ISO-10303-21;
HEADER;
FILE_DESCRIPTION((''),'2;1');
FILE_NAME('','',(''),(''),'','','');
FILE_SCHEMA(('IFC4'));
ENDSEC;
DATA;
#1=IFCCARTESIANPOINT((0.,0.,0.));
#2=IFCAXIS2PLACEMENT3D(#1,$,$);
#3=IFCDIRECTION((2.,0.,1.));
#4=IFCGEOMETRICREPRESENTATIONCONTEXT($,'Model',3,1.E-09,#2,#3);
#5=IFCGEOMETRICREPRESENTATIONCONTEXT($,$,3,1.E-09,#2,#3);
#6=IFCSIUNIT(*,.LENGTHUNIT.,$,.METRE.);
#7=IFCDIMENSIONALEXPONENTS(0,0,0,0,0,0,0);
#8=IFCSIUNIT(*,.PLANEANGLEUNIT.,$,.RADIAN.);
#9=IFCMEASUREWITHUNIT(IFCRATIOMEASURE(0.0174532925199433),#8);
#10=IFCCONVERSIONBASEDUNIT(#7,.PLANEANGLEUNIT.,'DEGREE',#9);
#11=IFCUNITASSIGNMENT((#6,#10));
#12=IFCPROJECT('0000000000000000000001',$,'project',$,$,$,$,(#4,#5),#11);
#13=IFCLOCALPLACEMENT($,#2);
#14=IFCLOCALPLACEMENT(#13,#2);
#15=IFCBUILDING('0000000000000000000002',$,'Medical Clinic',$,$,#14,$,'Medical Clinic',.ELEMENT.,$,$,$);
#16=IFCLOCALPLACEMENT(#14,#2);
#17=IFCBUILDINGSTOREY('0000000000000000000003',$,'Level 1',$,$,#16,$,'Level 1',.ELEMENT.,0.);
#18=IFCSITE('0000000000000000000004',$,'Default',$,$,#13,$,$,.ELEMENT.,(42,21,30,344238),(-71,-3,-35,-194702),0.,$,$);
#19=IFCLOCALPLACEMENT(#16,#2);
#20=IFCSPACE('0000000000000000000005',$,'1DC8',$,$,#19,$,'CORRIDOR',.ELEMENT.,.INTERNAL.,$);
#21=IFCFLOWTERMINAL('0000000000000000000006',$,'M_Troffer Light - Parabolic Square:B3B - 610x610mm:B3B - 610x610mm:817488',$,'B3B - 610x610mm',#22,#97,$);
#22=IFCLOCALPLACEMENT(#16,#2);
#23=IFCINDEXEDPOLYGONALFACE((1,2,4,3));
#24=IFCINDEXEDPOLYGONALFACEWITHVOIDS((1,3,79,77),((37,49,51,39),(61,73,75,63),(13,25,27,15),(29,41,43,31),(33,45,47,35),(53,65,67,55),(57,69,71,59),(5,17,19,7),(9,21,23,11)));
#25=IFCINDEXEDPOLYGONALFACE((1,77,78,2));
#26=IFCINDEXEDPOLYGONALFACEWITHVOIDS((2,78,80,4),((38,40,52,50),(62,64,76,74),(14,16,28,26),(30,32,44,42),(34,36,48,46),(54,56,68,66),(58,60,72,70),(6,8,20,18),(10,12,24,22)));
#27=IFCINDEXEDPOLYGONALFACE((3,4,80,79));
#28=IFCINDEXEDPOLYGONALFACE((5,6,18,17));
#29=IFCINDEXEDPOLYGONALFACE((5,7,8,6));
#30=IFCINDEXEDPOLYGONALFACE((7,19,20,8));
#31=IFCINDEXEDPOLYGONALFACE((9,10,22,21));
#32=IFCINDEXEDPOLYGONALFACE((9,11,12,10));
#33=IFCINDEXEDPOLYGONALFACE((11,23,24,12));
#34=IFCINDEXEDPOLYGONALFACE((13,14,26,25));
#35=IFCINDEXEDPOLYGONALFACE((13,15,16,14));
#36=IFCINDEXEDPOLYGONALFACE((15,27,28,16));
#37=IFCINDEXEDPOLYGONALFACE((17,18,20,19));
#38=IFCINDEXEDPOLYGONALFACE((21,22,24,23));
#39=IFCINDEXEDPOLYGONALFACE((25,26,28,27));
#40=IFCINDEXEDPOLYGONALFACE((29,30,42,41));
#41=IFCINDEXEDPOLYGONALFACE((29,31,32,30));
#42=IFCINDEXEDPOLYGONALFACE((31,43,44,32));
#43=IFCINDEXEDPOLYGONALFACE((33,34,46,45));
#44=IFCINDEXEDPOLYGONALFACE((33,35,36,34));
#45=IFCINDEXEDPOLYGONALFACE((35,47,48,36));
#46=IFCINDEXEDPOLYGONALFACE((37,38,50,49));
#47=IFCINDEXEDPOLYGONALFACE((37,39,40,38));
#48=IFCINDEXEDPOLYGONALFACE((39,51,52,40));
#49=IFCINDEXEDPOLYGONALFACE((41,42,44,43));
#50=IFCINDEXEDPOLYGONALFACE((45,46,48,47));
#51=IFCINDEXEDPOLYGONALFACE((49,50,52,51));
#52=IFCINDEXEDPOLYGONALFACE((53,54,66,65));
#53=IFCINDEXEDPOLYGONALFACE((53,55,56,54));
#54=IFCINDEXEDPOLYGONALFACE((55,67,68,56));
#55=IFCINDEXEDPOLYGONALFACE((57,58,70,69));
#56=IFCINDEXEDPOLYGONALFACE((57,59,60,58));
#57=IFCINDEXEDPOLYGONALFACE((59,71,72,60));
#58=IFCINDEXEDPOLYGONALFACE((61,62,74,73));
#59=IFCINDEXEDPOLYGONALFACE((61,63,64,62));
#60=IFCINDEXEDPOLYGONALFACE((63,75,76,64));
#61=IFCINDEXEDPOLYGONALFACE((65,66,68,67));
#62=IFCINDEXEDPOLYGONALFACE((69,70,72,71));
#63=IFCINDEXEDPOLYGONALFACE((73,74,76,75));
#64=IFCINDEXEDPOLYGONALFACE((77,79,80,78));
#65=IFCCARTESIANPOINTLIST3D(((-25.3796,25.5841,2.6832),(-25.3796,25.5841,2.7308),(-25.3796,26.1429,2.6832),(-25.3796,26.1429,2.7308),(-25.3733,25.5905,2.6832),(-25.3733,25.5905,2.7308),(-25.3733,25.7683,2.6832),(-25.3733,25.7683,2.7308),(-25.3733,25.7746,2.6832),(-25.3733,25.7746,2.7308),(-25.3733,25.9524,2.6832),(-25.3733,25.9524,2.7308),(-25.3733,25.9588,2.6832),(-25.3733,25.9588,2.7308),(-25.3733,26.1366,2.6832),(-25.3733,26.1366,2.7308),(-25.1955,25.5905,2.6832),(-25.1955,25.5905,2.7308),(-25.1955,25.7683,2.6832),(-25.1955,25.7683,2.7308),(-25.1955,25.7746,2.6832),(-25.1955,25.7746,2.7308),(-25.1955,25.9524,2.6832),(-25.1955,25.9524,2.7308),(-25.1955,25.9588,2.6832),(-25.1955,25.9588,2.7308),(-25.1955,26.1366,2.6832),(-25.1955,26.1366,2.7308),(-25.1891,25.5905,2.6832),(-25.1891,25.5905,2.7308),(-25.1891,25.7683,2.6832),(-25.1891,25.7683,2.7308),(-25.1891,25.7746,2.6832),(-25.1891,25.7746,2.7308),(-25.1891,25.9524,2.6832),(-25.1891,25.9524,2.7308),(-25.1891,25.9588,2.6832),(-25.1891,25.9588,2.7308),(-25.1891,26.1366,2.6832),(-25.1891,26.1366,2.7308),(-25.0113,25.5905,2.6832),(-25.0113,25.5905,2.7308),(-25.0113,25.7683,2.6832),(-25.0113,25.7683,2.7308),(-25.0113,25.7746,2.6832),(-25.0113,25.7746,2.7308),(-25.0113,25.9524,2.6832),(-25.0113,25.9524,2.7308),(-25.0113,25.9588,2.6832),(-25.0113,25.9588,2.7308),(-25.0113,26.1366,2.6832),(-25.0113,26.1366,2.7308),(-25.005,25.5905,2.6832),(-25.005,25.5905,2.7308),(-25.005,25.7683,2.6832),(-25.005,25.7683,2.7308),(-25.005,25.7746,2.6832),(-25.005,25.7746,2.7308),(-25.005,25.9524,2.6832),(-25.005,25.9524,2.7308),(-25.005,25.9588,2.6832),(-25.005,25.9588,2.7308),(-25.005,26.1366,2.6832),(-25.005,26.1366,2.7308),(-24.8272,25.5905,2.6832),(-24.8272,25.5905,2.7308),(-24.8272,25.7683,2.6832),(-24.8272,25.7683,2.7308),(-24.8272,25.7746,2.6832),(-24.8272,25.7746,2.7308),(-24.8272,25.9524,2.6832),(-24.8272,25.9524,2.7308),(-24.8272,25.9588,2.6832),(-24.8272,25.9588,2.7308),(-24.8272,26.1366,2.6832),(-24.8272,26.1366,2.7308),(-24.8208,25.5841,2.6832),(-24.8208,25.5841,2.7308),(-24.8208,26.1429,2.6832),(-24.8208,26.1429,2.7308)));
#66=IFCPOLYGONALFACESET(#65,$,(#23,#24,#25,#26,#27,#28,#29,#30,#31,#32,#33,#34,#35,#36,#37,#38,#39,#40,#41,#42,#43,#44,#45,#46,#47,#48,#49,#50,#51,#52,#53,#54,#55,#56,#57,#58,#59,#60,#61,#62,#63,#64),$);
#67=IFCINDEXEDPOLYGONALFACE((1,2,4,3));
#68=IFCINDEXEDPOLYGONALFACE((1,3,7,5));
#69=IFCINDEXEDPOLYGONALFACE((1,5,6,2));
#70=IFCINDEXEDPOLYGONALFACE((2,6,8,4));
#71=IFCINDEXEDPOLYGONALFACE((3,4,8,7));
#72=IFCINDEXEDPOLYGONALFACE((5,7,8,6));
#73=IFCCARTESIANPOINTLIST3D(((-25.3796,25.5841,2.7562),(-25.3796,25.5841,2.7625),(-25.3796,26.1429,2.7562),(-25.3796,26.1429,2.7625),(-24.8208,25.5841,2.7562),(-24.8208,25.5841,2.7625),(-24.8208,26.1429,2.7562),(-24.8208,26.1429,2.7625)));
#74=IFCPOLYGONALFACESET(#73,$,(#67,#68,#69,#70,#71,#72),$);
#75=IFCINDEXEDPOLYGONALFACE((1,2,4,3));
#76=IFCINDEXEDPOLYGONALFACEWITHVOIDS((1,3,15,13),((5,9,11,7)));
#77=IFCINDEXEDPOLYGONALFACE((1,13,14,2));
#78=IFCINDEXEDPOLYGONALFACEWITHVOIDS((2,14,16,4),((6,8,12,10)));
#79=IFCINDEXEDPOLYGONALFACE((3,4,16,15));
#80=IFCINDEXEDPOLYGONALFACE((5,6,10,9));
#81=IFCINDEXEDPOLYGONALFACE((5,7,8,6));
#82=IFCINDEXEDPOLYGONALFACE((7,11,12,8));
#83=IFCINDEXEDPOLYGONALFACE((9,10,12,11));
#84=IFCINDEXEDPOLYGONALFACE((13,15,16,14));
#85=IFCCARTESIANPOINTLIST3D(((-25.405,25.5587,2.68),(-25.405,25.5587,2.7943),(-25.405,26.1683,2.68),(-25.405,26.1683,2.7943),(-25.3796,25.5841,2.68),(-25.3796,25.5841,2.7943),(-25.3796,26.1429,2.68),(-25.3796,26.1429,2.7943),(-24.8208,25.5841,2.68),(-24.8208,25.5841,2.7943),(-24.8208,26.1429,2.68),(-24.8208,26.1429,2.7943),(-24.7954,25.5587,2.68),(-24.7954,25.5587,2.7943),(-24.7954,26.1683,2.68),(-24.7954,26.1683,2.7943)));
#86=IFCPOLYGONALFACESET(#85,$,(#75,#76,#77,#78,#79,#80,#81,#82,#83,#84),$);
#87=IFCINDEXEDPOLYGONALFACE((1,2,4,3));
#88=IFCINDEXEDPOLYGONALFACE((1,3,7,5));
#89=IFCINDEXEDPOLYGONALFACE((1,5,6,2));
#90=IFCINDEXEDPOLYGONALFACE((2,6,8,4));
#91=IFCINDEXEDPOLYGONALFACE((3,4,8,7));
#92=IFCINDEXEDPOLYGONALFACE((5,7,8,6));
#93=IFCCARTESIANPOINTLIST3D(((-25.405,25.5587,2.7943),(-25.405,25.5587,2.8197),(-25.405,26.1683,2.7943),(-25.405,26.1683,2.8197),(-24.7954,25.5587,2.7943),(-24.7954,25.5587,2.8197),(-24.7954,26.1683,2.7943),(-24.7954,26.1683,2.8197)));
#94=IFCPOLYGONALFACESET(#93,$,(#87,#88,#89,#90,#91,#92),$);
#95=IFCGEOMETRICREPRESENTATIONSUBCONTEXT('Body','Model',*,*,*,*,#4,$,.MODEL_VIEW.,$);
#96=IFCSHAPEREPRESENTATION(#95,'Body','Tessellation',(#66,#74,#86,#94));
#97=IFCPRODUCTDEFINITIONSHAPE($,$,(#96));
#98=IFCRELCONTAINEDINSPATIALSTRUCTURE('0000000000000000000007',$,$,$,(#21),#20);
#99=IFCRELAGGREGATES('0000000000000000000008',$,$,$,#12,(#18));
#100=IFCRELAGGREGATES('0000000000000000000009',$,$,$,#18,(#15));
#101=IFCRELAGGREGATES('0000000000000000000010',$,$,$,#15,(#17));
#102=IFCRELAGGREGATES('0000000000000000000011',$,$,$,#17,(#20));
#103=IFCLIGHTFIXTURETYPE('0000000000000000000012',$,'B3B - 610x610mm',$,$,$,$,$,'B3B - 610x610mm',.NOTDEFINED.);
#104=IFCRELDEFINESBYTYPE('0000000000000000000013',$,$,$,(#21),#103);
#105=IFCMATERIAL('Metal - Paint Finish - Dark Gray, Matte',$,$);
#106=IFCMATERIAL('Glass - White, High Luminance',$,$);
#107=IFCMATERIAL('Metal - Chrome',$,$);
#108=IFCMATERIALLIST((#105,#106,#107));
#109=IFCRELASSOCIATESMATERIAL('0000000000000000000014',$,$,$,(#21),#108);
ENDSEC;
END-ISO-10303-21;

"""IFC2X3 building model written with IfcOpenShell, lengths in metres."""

from ifc_helpers import new_model, entity, si_unit, converted_unit, direction, frame, origin, origin_2d_with_axis, place, context, subcontext, project, spatial, polyline, rectangle, outline, extrude, source, transform, mapped, material, material_list, type_object, type_shapes, element, save


model = new_model("IFC2X3")

# Units and contexts
model_context = context("Model", 3, precision=1e-09, world=origin(), true_north=direction((2.0, 0.0, 1.0)))
context_of_model = context(None, 3, precision=1e-09, world=origin(), true_north=direction((2.0, 0.0, 1.0)))
body_context = subcontext(model_context, "Body", "Model", "MODEL_VIEW")
ifc_project = project(units=[si_unit("LENGTHUNIT", "METRE"), converted_unit("PLANEANGLEUNIT", "DEGREE", entity("IfcRatioMeasure", 0.0174532925199433), si_unit("PLANEANGLEUNIT", "RADIAN"), dimensions=[0, 0, 0, 0, 0, 0, 0])], contexts=[model_context, context_of_model])

# Site, building, storey
site_placement = place(None, origin())
site = spatial("IfcSite", under=ifc_project, at=site_placement, Name="Default", CompositionType="ELEMENT", RefLatitude=(42, 21, 30, 344238), RefLongitude=(-71, -3, -35, -194702), RefElevation=0.0)
building_placement = place(site_placement, origin())
building = spatial("IfcBuilding", under=site, at=building_placement, Name="Medical Clinic", LongName="Medical Clinic", CompositionType="ELEMENT")
storey_placement = place(building_placement, origin())
storey = spatial("IfcBuildingStorey", under=building, at=storey_placement, Name="Level 1", LongName="Level 1", CompositionType="ELEMENT", Elevation=0.0)

# Shared definitions
space_1_placement = place(storey_placement, origin())
space_1 = spatial("IfcSpace", under=storey, at=space_1_placement, Name="1DC8", LongName="CORRIDOR", CompositionType="ELEMENT", InteriorOrExteriorSpace="INTERNAL")

# Flow terminal
ifc_material_1 = material(Name="Metal - Paint Finish - Dark Gray, Matte")
ifc_material_2 = material(Name="Glass - White, High Luminance")
ifc_material_3 = material(Name="Metal - Chrome")
ifc_material_list = material_list([ifc_material_1, ifc_material_2, ifc_material_3])
light_fixture_type_1 = type_object("IfcLightFixtureType", Name="B3B - 610x610mm", ElementType="B3B - 610x610mm", PredefinedType="NOTDEFINED")
shared_shape_1 = source(origin(), body_context, "Body", "SweptSolid", [
    extrude(outline(polyline([(-0.2794, -0.2794), (0.2794, -0.2794), (0.2794, 0.2794), (-0.2794, 0.2794), (-0.2794, -0.2794)]), holes=[polyline([(-0.0952, 0.0953), (-0.273, 0.0953), (-0.273, 0.2731), (-0.0952, 0.2731), (-0.0952, 0.0953)]), polyline([(0.2731, 0.0953), (0.0953, 0.0953), (0.0953, 0.2731), (0.2731, 0.2731), (0.2731, 0.0953)]), polyline([(-0.0889, 0.2731), (0.0889, 0.2731), (0.0889, 0.0953), (-0.0889, 0.0953), (-0.0889, 0.2731)]), polyline([(0.2731, -0.273), (0.0953, -0.273), (0.0953, -0.0952), (0.2731, -0.0952), (0.2731, -0.273)]), polyline([(0.0889, -0.273), (-0.0889, -0.273), (-0.0889, -0.0952), (0.0889, -0.0952), (0.0889, -0.273)]), polyline([(-0.0952, -0.273), (-0.273, -0.273), (-0.273, -0.0952), (-0.0952, -0.0952), (-0.0952, -0.273)]), polyline([(-0.0952, -0.0889), (-0.273, -0.0889), (-0.273, 0.0889), (-0.0952, 0.0889), (-0.0952, -0.0889)]), polyline([(0.0889, -0.0889), (-0.0889, -0.0889), (-0.0889, 0.0889), (0.0889, 0.0889), (0.0889, -0.0889)]), polyline([(0.2731, -0.0889), (0.0953, -0.0889), (0.0953, 0.0889), (0.2731, 0.0889), (0.2731, -0.0889)])]), frame((0.0, -0.3048, -0.0508), z_axis=(0.0, 0.0, 1.0), x_axis=(-1.0, 0.0, 0.0)), (0.0, 0.0, 1.0), 0.0476),
    extrude(rectangle(XDim=0.5588, YDim=0.5588, at=origin_2d_with_axis()), frame((0.0, -0.3048, -0.0825), z_axis=(0.0, 0.0, 1.0), x_axis=(-1.0, 0.0, 0.0)), (0.0, 0.0, 1.0), 0.0064),
    extrude(outline(polyline([(-0.3048, -0.3048), (0.3048, -0.3048), (0.3048, 0.3048), (-0.3048, 0.3048), (-0.3048, -0.3048)]), holes=[polyline([(0.2794, 0.2794), (0.2794, -0.2794), (-0.2794, -0.2794), (-0.2794, 0.2794), (0.2794, 0.2794)])]), frame((0.0, -0.3048, -0.1143)), (0.0, 0.0, 1.0), 0.1143),
    extrude(rectangle(XDim=0.6096, YDim=0.6096, at=origin_2d_with_axis()), frame((0.0, -0.3048, -0.1397), z_axis=(0.0, 0.0, 1.0), x_axis=(-1.0, 0.0, 0.0)), (0.0, 0.0, 1.0), 0.0254),
])
type_shapes(light_fixture_type_1, [shared_shape_1])
flow_terminal_1_placement = place(space_1_placement, frame((-25.1002, 25.5587, 2.68), z_axis=(0.0, 0.0, -1.0), x_axis=(1.0, 0.0, 0.0)))
element("IfcFlowTerminal", 1, at=flow_terminal_1_placement, inside=space_1, type_object=light_fixture_type_1, material=ifc_material_list, Name="M_Troffer Light - Parabolic Square:B3B - 610x610mm:B3B - 610x610mm:817488", ObjectType="B3B - 610x610mm", context=body_context, shape_type="MappedRepresentation", body=[
    mapped(shared_shape_1, transform((0.0, 0.0, 0.0), scale=1.0)),
])

save(model, "model.ifc")
